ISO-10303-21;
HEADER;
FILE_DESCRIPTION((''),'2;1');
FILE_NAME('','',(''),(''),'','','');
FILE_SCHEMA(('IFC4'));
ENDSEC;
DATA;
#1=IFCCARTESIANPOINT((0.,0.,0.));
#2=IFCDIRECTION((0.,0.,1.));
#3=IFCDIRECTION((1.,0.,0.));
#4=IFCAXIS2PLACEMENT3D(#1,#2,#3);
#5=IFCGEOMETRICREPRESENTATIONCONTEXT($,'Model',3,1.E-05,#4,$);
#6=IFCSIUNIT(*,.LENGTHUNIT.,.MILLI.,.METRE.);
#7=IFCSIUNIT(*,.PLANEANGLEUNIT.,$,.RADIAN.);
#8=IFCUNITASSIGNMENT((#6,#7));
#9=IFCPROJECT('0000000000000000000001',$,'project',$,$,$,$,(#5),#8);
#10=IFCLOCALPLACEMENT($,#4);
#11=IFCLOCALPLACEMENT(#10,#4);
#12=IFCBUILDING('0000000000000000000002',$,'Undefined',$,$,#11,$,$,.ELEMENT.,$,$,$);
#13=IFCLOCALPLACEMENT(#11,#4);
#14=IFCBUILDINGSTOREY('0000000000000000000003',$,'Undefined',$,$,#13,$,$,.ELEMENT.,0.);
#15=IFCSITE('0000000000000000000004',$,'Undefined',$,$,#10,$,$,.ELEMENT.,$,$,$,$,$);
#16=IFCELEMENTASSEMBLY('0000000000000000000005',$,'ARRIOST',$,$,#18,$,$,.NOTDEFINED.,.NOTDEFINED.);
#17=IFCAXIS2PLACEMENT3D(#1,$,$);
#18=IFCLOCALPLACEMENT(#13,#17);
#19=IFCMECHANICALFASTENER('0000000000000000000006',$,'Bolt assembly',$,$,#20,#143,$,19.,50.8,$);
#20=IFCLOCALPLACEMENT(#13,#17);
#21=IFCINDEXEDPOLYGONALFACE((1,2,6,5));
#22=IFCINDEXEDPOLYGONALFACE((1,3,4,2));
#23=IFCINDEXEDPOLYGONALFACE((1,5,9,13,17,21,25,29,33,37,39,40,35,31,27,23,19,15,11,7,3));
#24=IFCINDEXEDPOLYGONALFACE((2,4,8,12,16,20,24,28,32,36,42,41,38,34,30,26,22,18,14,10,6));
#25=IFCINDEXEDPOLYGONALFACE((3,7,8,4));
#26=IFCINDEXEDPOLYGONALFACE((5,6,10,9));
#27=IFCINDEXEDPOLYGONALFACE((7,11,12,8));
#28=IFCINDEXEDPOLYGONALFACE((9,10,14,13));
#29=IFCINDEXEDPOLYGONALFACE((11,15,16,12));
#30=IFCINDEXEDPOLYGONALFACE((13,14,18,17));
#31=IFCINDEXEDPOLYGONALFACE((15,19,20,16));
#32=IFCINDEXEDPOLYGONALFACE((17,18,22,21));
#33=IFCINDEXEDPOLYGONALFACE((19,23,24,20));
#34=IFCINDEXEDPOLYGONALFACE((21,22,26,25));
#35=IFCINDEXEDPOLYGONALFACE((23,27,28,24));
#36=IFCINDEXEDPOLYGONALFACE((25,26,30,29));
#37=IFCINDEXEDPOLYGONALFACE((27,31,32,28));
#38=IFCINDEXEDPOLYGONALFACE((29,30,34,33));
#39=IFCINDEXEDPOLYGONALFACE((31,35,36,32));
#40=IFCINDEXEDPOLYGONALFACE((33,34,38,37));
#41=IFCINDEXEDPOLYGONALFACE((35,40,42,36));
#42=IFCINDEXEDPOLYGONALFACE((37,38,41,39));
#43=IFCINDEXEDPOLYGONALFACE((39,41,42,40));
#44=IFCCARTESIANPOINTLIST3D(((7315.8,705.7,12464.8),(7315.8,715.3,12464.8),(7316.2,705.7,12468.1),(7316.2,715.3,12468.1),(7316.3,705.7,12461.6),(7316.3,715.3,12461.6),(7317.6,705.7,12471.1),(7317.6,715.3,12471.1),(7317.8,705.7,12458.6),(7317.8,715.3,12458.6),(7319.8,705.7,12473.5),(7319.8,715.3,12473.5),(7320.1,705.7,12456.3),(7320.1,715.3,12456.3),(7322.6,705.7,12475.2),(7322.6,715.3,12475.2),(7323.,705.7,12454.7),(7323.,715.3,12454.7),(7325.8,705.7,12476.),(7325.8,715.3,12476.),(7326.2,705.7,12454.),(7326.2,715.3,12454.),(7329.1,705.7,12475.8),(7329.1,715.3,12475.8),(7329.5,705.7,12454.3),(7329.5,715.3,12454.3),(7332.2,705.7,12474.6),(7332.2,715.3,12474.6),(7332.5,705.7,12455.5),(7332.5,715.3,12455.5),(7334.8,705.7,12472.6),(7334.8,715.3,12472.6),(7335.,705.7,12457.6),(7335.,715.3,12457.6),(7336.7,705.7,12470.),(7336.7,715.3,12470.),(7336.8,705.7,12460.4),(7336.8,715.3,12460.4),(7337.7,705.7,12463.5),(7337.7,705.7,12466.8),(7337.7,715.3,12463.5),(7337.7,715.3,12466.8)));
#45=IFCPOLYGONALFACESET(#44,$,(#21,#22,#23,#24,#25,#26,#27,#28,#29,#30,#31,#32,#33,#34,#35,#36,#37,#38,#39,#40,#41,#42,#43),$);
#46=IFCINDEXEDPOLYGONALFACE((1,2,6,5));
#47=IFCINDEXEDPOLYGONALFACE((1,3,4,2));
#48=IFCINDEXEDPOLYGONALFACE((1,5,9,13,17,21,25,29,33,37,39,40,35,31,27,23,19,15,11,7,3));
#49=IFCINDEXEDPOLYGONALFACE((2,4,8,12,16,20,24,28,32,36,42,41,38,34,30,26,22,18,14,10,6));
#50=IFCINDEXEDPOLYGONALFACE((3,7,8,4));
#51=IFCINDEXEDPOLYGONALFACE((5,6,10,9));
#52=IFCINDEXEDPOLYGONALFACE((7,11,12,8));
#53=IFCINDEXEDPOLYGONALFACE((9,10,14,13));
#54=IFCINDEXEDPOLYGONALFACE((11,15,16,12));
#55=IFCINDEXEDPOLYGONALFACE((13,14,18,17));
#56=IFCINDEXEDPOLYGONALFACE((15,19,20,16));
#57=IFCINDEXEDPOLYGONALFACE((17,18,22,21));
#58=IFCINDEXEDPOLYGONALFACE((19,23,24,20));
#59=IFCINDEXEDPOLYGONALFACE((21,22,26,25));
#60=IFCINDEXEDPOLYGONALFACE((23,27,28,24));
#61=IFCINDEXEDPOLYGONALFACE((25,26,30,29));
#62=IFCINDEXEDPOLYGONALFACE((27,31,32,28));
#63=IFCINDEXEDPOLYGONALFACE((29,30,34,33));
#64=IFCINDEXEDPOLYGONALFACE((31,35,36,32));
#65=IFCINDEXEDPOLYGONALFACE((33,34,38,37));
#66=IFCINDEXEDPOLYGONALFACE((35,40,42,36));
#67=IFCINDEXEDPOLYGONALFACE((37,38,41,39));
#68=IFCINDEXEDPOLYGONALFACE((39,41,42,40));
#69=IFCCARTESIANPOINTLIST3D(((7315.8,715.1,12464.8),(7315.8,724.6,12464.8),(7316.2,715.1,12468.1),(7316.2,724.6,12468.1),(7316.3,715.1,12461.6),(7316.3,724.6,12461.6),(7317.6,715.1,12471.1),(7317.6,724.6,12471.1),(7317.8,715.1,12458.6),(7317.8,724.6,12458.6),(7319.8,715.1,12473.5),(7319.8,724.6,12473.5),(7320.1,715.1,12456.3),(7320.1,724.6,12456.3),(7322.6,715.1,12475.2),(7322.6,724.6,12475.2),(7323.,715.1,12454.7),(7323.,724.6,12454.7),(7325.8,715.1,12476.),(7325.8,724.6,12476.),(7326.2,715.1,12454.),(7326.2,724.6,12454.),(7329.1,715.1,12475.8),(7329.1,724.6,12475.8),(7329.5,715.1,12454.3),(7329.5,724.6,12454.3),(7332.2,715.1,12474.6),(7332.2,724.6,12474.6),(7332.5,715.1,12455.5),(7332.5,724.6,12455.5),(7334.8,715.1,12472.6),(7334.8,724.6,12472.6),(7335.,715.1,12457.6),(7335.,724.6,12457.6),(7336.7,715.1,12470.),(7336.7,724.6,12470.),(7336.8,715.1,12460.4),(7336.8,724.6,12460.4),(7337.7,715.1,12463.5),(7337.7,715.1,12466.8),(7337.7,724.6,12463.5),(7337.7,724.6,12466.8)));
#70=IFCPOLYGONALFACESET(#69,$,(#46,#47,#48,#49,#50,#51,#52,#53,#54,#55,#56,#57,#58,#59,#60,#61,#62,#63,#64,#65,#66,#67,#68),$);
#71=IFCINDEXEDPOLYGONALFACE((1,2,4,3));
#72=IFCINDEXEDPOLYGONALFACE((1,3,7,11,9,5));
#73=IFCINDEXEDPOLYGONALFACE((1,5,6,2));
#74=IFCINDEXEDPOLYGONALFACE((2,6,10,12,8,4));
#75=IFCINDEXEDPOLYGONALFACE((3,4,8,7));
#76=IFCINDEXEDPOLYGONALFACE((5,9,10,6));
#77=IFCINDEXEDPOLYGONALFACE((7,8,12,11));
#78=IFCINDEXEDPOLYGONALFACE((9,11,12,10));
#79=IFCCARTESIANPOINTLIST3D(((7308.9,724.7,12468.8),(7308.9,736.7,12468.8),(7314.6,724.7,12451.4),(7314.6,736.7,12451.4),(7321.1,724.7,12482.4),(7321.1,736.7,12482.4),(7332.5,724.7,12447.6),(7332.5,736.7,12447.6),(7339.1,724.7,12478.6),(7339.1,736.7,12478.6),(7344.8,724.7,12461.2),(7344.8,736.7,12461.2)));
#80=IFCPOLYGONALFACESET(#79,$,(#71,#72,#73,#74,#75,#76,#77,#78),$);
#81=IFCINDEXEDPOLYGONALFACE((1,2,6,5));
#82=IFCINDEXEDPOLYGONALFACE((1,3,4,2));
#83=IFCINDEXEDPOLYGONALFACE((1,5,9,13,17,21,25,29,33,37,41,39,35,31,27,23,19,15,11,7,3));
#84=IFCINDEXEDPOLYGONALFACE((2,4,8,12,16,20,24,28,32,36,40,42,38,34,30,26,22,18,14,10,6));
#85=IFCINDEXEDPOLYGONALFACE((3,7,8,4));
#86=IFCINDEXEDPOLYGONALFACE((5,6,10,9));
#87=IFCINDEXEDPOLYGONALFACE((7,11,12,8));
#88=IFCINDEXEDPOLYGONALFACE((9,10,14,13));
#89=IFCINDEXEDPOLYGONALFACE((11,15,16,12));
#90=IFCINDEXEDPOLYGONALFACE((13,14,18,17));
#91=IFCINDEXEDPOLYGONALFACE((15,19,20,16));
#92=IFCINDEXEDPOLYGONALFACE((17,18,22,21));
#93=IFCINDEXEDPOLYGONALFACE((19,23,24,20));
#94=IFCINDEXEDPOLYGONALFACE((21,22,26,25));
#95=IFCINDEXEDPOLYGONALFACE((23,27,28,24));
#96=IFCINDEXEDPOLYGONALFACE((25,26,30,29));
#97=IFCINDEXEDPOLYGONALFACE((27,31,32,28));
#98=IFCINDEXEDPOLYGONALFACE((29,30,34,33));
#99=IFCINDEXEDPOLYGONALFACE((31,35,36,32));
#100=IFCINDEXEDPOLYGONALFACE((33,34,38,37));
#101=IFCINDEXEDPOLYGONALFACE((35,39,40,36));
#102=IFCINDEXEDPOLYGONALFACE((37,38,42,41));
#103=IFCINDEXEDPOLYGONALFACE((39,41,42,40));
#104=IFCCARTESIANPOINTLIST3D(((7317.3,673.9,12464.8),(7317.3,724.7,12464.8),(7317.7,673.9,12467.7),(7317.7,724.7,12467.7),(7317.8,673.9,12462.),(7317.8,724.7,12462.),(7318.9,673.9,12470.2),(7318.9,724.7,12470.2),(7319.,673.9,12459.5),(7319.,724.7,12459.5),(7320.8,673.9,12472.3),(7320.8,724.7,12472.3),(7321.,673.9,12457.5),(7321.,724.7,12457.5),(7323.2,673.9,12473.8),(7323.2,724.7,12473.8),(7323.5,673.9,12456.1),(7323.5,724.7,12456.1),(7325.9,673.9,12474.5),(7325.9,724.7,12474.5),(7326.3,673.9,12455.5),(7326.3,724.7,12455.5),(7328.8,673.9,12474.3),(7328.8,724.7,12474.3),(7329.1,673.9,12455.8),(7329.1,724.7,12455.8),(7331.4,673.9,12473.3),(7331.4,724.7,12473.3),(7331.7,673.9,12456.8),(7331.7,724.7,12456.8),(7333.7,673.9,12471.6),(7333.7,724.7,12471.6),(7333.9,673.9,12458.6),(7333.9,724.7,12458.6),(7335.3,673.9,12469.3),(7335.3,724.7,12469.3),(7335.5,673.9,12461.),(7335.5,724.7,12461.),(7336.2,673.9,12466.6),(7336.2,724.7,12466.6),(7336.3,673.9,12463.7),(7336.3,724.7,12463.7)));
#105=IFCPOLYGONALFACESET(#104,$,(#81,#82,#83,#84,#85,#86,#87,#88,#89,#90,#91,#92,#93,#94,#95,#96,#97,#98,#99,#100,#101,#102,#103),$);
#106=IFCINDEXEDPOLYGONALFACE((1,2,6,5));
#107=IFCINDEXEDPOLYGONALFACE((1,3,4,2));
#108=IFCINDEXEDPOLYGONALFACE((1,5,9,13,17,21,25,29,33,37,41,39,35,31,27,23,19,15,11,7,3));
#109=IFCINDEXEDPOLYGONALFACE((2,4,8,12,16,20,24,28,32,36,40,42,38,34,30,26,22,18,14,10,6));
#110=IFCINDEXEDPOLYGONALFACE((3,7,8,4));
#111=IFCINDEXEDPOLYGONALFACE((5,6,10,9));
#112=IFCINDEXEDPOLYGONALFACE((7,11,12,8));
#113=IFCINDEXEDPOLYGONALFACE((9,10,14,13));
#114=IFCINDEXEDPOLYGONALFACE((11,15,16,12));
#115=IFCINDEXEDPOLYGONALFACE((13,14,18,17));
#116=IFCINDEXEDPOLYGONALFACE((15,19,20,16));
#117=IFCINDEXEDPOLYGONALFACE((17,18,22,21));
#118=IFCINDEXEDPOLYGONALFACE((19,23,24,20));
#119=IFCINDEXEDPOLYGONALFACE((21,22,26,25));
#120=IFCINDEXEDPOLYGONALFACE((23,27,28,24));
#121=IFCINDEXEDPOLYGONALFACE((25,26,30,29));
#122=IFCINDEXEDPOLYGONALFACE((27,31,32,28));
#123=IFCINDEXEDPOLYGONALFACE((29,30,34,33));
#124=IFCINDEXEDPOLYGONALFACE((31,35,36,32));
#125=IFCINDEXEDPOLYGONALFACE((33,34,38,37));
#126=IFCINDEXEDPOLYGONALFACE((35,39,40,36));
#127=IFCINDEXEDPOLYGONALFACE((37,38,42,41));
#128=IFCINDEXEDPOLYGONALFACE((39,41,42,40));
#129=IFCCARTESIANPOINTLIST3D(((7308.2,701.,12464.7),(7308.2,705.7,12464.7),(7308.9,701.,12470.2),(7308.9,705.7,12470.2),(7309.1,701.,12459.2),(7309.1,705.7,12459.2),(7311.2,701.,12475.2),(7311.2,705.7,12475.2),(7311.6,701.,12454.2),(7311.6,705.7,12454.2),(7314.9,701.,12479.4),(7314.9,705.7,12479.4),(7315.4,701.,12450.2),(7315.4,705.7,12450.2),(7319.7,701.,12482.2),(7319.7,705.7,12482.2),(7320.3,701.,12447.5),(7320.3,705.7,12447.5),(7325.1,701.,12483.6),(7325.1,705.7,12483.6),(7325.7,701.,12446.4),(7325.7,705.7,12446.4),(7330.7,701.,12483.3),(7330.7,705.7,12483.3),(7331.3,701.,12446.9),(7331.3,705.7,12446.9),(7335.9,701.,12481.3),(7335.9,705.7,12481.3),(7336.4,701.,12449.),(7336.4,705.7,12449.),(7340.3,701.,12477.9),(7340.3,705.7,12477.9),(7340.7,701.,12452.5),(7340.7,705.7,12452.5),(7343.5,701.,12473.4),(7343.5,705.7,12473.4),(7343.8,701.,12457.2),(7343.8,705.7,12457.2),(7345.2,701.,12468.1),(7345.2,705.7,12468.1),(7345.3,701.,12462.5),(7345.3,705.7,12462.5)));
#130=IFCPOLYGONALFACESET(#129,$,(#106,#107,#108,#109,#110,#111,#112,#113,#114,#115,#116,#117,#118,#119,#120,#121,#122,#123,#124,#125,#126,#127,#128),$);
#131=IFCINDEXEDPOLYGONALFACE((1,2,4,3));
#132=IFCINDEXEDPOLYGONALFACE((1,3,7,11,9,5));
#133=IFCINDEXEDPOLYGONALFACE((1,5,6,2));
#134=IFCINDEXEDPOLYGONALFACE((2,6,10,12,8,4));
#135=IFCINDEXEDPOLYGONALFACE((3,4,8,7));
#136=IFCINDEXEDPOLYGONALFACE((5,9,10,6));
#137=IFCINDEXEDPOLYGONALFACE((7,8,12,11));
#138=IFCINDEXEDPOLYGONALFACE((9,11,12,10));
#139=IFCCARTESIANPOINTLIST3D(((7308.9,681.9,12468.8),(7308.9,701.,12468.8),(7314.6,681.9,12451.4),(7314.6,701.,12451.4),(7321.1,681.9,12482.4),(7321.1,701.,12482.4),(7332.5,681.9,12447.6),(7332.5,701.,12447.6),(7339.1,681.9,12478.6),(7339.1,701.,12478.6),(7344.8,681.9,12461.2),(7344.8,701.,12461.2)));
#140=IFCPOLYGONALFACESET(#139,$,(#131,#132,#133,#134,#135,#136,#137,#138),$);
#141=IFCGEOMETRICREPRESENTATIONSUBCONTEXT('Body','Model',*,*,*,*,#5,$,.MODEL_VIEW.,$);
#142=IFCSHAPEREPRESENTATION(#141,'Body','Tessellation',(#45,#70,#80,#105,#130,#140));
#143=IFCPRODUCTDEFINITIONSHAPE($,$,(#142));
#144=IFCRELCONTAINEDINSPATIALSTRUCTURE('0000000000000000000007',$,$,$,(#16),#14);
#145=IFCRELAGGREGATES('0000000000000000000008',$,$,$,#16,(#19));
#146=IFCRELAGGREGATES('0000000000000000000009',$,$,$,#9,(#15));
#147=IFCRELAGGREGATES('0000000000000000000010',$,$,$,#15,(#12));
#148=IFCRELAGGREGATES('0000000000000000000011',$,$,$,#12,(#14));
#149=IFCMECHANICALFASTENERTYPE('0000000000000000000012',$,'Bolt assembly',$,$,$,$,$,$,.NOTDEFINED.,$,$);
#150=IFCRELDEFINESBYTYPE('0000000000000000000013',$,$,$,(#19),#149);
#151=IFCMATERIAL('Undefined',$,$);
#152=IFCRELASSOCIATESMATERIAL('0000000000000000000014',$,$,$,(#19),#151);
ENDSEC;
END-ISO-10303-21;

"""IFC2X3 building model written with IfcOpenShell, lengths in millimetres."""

from ifc_helpers import new_model, si_unit, frame, origin_with_axes, origin_2d_with_axis, place, context, subcontext, project, spatial, polyline, circle, outline, extrude, source, transform, mapped, material, type_object, element, aggregate, save


model = new_model("IFC2X3")

# Units and contexts
model_context = context("Model", 3, precision=1e-05, world=origin_with_axes())
body_context = subcontext(model_context, "Body", "Model", "MODEL_VIEW")
ifc_project = project(units=[si_unit("LENGTHUNIT", "METRE", prefix="MILLI"), si_unit("PLANEANGLEUNIT", "RADIAN")], contexts=[model_context])

# Site, building, storey
site_placement = place(None, origin_with_axes())
site = spatial("IfcSite", under=ifc_project, at=site_placement, Name="Undefined", CompositionType="ELEMENT")
building_placement = place(site_placement, origin_with_axes())
building = spatial("IfcBuilding", under=site, at=building_placement, Name="Undefined", CompositionType="ELEMENT")
storey_placement = place(building_placement, origin_with_axes())
storey = spatial("IfcBuildingStorey", under=building, at=storey_placement, Name="Undefined", CompositionType="ELEMENT", Elevation=0.0)

# Element assembly
assembly_1_placement = place(storey_placement, origin_with_axes())
assembly_1 = element("IfcElementAssembly", 1, at=assembly_1_placement, inside=storey, Name="ARRIOST", AssemblyPlace="NOTDEFINED", PredefinedType="NOTDEFINED")

# Shared definitions
ifc_material_1 = material(Name="Undefined")
mechanical_fastener_type = type_object("IfcMechanicalFastenerType", Name="Bolt assembly")

# Mechanical fastener
shared_shape_1 = source(origin_with_axes(), body_context, "Body", "SweptSolid", [
    extrude(circle(Radius=11.0, at=origin_2d_with_axis()), frame((0.0, 4.6, 0.0), z_axis=(0.0, 1.0, 0.0), x_axis=(1.0, 0.0, 0.0)), (0.0, 0.0, 1.0), 9.6),
    extrude(circle(Radius=11.0, at=origin_2d_with_axis()), frame((0.0, -4.6, 0.0), z_axis=(0.0, 1.0, 0.0), x_axis=(1.0, 0.0, 0.0)), (0.0, 0.0, 1.0), 9.5),
    extrude(outline(polyline([(15.9, -9.2), (15.9, 9.2), (0.0, 18.3), (-15.9, 9.2), (-15.9, -9.2), (0.0, -18.3), (15.9, -9.2)])), frame((0.0, -16.7, 0.0), z_axis=(0.0, 1.0, 0.0), x_axis=(1.0, 0.0, 0.0)), (0.0, 0.0, 1.0), 11.9),
    extrude(circle(Radius=9.5, at=origin_2d_with_axis()), frame((0.0, -4.7, 0.0), z_axis=(0.0, 1.0, 0.0), x_axis=(1.0, 0.0, 0.0)), (0.0, 0.0, 1.0), 50.8),
    extrude(circle(Radius=18.7, at=origin_2d_with_axis()), frame((0.0, 14.2, 0.0), z_axis=(0.0, 1.0, 0.0), x_axis=(1.0, 0.0, 0.0)), (0.0, 0.0, 1.0), 4.8),
    extrude(outline(polyline([(15.9, -9.2), (15.9, 9.2), (0.0, 18.3), (-15.9, 9.2), (-15.9, -9.2), (0.0, -18.3), (15.9, -9.2)])), frame((0.0, 19.0, 0.0), z_axis=(0.0, 1.0, 0.0), x_axis=(1.0, 0.0, 0.0)), (0.0, 0.0, 1.0), 19.1),
])
mechanical_fastener_1_placement = place(assembly_1_placement, frame((7326.8, 720.0, 12465.0), z_axis=(-0.310822, 0.0, 0.950468), x_axis=(-0.950468, 0.0, -0.310822)))
mechanical_fastener_1 = element("IfcMechanicalFastener", 2, at=mechanical_fastener_1_placement, type_object=mechanical_fastener_type, material=ifc_material_1, Name="Bolt assembly", NominalDiameter=19.0, NominalLength=50.8, context=body_context, shape_type="MappedRepresentation", body=[
    mapped(shared_shape_1, transform((0.0, 0.0, 0.0))),
])
aggregate(assembly_1, [mechanical_fastener_1])

save(model, "model.ifc")
